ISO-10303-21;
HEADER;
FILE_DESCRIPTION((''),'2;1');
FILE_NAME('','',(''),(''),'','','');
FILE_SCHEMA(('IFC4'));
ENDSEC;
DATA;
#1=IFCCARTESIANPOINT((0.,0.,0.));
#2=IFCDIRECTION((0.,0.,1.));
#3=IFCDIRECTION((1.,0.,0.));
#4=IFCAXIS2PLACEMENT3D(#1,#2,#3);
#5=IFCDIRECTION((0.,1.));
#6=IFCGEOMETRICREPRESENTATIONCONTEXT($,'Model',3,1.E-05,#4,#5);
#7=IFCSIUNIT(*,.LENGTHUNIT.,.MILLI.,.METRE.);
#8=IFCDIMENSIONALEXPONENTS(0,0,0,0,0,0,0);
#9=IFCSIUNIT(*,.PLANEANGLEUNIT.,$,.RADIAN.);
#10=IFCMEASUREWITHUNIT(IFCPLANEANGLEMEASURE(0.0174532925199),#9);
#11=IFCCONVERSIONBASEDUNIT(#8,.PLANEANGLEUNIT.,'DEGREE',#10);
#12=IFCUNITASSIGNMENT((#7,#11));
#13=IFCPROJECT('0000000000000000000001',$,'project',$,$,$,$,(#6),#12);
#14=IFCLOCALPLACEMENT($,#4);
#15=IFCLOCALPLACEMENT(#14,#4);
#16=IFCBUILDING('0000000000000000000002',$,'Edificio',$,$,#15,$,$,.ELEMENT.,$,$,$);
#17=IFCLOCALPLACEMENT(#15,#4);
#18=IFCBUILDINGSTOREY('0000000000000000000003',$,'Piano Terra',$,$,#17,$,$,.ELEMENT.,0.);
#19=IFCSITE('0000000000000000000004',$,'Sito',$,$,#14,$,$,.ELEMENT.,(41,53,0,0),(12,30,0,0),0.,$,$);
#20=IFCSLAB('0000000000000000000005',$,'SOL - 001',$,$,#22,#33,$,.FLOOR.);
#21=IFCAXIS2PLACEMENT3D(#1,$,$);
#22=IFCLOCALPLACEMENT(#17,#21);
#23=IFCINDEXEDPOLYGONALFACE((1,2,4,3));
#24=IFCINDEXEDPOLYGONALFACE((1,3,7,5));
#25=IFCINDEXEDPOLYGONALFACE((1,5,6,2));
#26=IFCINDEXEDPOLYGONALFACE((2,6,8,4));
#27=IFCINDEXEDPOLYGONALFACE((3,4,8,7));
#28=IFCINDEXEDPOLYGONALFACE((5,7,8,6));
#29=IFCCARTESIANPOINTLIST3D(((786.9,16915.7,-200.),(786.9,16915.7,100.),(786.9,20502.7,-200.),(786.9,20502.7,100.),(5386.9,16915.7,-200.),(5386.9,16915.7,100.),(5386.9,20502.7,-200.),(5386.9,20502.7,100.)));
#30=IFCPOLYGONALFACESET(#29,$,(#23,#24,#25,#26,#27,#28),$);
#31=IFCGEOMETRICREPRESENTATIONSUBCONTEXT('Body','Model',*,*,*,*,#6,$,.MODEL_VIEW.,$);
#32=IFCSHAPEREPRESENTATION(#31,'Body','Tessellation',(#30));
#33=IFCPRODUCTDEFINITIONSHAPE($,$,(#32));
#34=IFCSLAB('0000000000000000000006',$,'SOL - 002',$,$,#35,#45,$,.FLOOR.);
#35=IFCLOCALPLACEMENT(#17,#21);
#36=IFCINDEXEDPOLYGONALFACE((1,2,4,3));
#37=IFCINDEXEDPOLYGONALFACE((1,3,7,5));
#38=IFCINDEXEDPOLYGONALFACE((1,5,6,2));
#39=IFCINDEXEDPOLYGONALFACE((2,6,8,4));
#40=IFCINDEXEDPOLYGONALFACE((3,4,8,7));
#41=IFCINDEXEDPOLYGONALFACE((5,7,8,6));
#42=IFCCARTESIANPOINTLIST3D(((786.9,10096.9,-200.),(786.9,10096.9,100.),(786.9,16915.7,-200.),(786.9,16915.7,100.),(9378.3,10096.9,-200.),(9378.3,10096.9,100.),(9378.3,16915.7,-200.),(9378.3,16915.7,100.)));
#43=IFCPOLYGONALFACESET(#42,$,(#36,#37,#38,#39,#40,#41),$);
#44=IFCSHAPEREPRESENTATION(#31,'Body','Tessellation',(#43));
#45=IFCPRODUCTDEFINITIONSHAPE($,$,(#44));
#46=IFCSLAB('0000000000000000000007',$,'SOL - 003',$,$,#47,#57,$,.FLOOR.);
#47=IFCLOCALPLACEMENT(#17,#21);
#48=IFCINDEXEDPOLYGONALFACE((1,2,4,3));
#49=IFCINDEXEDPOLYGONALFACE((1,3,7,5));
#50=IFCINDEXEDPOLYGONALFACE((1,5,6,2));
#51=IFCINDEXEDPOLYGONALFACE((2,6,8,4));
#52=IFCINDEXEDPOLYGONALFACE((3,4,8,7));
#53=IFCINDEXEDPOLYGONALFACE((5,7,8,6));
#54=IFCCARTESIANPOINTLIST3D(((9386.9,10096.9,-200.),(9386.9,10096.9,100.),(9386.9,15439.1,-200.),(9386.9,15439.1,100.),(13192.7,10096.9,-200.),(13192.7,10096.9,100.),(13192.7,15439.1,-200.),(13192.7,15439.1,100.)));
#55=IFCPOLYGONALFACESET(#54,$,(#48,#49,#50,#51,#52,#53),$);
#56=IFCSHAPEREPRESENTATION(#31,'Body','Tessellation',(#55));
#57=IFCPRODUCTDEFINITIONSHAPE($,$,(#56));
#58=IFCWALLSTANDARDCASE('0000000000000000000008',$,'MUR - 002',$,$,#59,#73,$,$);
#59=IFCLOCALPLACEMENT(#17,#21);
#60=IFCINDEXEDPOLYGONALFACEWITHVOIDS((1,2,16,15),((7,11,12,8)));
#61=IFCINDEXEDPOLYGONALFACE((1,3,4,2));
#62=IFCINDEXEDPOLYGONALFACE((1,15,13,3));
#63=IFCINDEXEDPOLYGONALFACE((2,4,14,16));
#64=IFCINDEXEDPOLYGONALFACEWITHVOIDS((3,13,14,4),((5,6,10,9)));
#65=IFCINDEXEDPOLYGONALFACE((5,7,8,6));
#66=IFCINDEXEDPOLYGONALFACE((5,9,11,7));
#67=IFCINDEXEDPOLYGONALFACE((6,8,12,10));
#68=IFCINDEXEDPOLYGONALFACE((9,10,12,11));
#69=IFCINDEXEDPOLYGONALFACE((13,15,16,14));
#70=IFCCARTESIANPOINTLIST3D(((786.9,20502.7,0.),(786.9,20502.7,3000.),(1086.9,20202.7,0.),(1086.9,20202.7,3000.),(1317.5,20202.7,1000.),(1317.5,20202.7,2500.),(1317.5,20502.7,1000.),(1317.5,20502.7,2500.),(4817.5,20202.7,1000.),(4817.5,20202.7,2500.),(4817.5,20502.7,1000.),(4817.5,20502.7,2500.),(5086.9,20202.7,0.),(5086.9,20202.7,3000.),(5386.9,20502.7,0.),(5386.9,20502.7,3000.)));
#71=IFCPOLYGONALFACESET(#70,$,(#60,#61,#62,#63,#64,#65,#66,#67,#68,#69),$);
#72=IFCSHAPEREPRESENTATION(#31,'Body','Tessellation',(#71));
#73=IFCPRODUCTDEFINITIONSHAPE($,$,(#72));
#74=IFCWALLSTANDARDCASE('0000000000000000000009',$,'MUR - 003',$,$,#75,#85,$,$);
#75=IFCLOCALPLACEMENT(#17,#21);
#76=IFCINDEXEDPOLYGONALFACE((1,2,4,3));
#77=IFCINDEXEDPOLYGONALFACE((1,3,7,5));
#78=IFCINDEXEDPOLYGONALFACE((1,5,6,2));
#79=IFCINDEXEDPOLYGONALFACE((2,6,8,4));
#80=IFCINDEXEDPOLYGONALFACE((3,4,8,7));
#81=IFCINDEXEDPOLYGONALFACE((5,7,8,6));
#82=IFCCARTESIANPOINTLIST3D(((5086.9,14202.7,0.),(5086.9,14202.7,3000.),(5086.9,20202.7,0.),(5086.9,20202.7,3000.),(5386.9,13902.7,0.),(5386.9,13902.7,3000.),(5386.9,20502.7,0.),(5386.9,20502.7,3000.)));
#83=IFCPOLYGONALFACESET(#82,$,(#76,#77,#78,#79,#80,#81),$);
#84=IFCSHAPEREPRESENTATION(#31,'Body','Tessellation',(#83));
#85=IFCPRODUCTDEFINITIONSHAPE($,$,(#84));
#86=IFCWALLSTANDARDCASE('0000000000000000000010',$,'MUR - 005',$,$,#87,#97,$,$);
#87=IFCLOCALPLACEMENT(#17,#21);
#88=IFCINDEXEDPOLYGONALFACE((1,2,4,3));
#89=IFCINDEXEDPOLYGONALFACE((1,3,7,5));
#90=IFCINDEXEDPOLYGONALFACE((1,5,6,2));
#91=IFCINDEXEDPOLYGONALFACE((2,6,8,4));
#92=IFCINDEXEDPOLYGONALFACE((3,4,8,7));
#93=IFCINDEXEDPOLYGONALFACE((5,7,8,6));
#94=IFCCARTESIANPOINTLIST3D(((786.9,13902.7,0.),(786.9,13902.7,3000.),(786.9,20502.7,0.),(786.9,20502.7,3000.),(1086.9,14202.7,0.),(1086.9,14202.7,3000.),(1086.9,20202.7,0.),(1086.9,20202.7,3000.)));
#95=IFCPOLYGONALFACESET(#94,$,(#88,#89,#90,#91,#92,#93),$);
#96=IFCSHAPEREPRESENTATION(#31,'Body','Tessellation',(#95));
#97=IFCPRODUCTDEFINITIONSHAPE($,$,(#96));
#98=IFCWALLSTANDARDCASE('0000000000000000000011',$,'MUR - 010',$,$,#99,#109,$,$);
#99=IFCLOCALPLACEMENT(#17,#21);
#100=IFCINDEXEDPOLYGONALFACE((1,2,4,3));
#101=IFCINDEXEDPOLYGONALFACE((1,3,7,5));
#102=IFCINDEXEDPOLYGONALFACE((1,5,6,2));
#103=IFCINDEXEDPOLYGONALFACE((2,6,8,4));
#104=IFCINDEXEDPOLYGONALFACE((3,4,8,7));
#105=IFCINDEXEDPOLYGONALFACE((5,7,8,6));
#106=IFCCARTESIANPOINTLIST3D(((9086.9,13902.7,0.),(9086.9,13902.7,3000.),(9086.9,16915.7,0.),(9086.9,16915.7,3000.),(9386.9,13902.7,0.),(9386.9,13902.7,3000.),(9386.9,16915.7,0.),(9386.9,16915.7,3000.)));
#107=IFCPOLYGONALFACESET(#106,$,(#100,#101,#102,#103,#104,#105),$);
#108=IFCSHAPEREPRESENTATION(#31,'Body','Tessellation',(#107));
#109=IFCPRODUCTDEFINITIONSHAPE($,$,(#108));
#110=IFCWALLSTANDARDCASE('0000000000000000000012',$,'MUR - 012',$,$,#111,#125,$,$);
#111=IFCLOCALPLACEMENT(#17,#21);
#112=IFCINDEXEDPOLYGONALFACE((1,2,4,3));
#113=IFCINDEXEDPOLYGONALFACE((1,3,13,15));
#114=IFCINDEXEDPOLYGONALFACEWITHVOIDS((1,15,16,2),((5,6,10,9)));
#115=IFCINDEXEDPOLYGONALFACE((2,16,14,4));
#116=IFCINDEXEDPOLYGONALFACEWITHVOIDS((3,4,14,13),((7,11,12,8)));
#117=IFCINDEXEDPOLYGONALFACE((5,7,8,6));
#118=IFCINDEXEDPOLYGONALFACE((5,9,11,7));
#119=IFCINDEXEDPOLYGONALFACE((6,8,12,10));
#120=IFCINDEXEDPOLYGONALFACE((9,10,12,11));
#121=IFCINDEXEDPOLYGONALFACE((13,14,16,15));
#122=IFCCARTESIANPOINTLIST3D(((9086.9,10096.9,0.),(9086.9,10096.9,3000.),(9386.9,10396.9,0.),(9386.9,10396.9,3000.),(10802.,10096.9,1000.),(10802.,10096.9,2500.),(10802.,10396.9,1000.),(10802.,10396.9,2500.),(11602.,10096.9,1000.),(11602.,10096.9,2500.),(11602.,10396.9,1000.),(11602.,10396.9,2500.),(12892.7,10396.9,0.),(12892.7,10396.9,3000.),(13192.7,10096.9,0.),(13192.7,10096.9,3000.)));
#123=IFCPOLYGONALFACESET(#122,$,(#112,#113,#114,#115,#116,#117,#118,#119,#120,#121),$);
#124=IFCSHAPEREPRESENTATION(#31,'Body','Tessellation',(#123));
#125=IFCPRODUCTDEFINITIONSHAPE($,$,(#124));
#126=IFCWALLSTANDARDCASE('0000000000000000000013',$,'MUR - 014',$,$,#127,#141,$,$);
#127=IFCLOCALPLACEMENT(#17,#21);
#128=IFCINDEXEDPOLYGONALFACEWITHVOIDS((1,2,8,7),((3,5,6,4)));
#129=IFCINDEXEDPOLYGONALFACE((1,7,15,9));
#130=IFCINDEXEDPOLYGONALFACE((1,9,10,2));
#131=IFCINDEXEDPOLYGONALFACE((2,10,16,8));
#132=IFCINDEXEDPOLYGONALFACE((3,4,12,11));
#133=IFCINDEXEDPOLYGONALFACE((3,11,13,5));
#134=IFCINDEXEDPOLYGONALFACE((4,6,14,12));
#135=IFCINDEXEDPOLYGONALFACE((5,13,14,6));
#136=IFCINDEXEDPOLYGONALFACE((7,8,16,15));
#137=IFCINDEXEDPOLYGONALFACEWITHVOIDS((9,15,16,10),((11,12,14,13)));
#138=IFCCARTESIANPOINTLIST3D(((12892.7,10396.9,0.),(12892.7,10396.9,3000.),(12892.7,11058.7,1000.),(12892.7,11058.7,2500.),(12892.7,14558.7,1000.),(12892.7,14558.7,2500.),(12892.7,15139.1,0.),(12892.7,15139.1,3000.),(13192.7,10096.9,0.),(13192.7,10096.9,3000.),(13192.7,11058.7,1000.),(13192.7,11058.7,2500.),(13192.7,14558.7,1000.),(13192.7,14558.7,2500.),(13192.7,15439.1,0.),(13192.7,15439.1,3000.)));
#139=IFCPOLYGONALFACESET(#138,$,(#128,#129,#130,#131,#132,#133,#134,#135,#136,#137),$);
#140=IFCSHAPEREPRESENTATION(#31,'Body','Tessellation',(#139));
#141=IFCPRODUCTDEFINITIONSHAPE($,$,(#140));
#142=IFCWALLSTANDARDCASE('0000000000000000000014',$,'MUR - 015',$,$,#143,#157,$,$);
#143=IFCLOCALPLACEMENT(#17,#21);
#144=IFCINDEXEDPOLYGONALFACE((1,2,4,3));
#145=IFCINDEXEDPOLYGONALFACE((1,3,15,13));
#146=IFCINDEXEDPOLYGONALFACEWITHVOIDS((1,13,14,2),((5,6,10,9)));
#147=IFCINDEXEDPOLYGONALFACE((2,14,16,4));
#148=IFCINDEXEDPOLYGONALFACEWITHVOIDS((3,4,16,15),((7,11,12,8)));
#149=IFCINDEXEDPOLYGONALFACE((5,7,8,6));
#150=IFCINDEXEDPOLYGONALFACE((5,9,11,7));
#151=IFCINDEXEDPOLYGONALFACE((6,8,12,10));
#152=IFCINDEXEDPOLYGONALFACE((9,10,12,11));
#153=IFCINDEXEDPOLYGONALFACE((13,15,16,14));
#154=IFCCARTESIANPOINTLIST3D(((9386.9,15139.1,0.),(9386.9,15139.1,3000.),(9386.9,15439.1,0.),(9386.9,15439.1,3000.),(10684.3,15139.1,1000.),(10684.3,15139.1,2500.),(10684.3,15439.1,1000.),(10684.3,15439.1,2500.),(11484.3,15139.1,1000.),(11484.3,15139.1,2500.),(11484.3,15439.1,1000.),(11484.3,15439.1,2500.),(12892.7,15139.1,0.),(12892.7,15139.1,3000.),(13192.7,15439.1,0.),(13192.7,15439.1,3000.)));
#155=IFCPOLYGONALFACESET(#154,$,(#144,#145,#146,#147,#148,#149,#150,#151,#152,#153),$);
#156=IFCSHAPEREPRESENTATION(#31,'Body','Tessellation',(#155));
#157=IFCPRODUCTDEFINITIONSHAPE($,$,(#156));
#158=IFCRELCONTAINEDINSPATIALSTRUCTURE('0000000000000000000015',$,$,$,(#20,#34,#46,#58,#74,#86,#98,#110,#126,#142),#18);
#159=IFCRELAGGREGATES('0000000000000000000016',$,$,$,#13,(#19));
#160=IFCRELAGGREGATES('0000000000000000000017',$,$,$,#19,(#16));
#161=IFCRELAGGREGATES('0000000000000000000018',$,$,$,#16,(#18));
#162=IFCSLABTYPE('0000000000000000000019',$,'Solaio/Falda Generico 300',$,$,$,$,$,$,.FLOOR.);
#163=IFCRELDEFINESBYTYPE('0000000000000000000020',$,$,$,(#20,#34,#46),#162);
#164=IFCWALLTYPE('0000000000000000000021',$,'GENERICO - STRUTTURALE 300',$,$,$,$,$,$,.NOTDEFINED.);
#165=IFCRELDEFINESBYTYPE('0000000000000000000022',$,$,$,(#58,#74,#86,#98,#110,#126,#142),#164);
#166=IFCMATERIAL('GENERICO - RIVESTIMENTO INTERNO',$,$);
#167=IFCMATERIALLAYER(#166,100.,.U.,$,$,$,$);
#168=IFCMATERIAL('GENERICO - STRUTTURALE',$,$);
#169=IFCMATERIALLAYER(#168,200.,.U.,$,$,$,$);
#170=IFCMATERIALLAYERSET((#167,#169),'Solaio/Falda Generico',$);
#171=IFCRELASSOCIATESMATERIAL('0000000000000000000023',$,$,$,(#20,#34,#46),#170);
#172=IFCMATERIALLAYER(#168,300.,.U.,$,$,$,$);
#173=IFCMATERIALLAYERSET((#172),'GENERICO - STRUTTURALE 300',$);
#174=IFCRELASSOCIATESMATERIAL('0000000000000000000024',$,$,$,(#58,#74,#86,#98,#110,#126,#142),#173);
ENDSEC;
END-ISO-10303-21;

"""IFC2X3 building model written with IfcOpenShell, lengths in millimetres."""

from ifc_helpers import new_model, entity, si_unit, converted_unit, direction, frame, origin_with_axes, origin_2d_with_axis, place, context, subcontext, project, spatial, polyline, rectangle, outline, extrude, material, layer, layer_set, layer_usage, type_object, element, save


model = new_model("IFC2X3")

# Units and contexts
model_context = context("Model", 3, precision=1e-05, world=origin_with_axes(), true_north=direction((0.0, 1.0)))
body_context = subcontext(model_context, "Body", "Model", "MODEL_VIEW")
ifc_project = project(units=[si_unit("LENGTHUNIT", "METRE", prefix="MILLI"), converted_unit("PLANEANGLEUNIT", "DEGREE", entity("IfcPlaneAngleMeasure", 0.0174532925199), si_unit("PLANEANGLEUNIT", "RADIAN"), dimensions=[0, 0, 0, 0, 0, 0, 0])], contexts=[model_context])

# Site, building, storey
site_placement = place(None, origin_with_axes())
site = spatial("IfcSite", under=ifc_project, at=site_placement, Name="Sito", CompositionType="ELEMENT", RefLatitude=(41, 53, 0, 0), RefLongitude=(12, 30, 0, 0), RefElevation=0.0)
building_placement = place(site_placement, origin_with_axes())
building = spatial("IfcBuilding", under=site, at=building_placement, Name="Edificio", CompositionType="ELEMENT")
storey_placement = place(building_placement, origin_with_axes())
storey = spatial("IfcBuildingStorey", under=building, at=storey_placement, Name="Piano Terra", CompositionType="ELEMENT", Elevation=0.0)

# Slabs
ifc_material_1 = material(Name="GENERICO - RIVESTIMENTO INTERNO")
ifc_layer_1 = layer(ifc_material_1, 100.0, ventilated="UNKNOWN")
ifc_material_2 = material(Name="GENERICO - STRUTTURALE")
ifc_layer_2 = layer(ifc_material_2, 200.0, ventilated="UNKNOWN")
ifc_layer_set_1 = layer_set([ifc_layer_1, ifc_layer_2], Name="Solaio/Falda Generico")
ifc_layer_usage_1 = layer_usage(ifc_layer_set_1, "AXIS3", "NEGATIVE", 300.0)
slab_type = type_object("IfcSlabType", Name="Solaio/Falda Generico 300", PredefinedType="FLOOR")
slab_1_placement = place(storey_placement, frame((786.9, 16915.7, 0.0), z_axis=(0.0, 0.0, 1.0), x_axis=(1.0, 0.0, 0.0)))
element("IfcSlab", 1, at=slab_1_placement, inside=storey, type_object=slab_type, material=ifc_layer_usage_1, Name="SOL - 001", PredefinedType="FLOOR", context=body_context, shape_type="SweptSolid", body=[
    extrude(outline(polyline([(0.0, 0.0), (4600.0, 0.0), (4600.0, 3587.1), (0.0, 3587.1), (0.0, 0.0)])), frame((0.0, 0.0, -200.0), z_axis=(0.0, 0.0, 1.0), x_axis=(1.0, 0.0, 0.0)), (0.0, 0.0, 1.0), 300.0),
])
ifc_layer_usage_2 = layer_usage(ifc_layer_set_1, "AXIS3", "NEGATIVE", 300.0)
slab_2_placement = place(storey_placement, frame((786.9, 10096.9, 0.0), z_axis=(0.0, 0.0, 1.0), x_axis=(1.0, 0.0, 0.0)))
element("IfcSlab", 2, at=slab_2_placement, inside=storey, type_object=slab_type, material=ifc_layer_usage_2, Name="SOL - 002", PredefinedType="FLOOR", context=body_context, shape_type="SweptSolid", body=[
    extrude(outline(polyline([(0.0, 0.0), (8591.4, 0.0), (8591.4, 6818.8), (0.0, 6818.8), (0.0, 0.0)])), frame((0.0, 0.0, -200.0), z_axis=(0.0, 0.0, 1.0), x_axis=(1.0, 0.0, 0.0)), (0.0, 0.0, 1.0), 300.0),
])
ifc_layer_usage_3 = layer_usage(ifc_layer_set_1, "AXIS3", "NEGATIVE", 300.0)
slab_3_placement = place(storey_placement, frame((9386.9, 10096.9, 0.0), z_axis=(0.0, 0.0, 1.0), x_axis=(1.0, 0.0, 0.0)))
element("IfcSlab", 3, at=slab_3_placement, inside=storey, type_object=slab_type, material=ifc_layer_usage_3, Name="SOL - 003", PredefinedType="FLOOR", context=body_context, shape_type="SweptSolid", body=[
    extrude(outline(polyline([(0.0, 0.0), (3805.8, 0.0), (3805.8, 5342.2), (0.0, 5342.2), (0.0, 0.0)])), frame((0.0, 0.0, -200.0), z_axis=(0.0, 0.0, 1.0), x_axis=(1.0, 0.0, 0.0)), (0.0, 0.0, 1.0), 300.0),
])

# Wall, opening
ifc_layer_3 = layer(ifc_material_2, 300.0, ventilated="UNKNOWN")
ifc_layer_set_2 = layer_set([ifc_layer_3], Name="GENERICO - STRUTTURALE 300")
ifc_layer_usage_4 = layer_usage(ifc_layer_set_2, "AXIS2", "POSITIVE", 0.0)
wall_type = type_object("IfcWallType", Name="GENERICO - STRUTTURALE 300", PredefinedType="NOTDEFINED")
wall_1_placement = place(storey_placement, frame((1086.9, 20202.7, 0.0), z_axis=(0.0, 0.0, 1.0), x_axis=(1.0, 0.0, 0.0)))
wall_1 = element("IfcWallStandardCase", 4, at=wall_1_placement, inside=storey, type_object=wall_type, material=ifc_layer_usage_4, Name="MUR - 002", context=body_context, shape_type="SweptSolid", body=[
    extrude(outline(polyline([(0.0, 0.0), (4000.0, 0.0), (4300.0, 300.0), (-300.0, 300.0), (0.0, 0.0)])), origin_with_axes(), (0.0, 0.0, 1.0), 3000.0),
])
opening_1_placement = place(wall_1_placement, frame((1980.6, 0.0, 1000.0), z_axis=(0.0, 0.0, 1.0), x_axis=(1.0, 0.0, 0.0)))
element("IfcOpeningElement", 5, at=opening_1_placement, cuts=wall_1, context=body_context, shape_type="SweptSolid", body=[
    extrude(rectangle(XDim=3500.0, YDim=1500.0, at=origin_2d_with_axis()), frame((0.0, -300.0, 750.0), z_axis=(0.0, 1.0, 0.0), x_axis=(1.0, 0.0, 0.0)), (0.0, 0.0, 1.0), 900.0),
])

# Wall
ifc_layer_usage_5 = layer_usage(ifc_layer_set_2, "AXIS2", "POSITIVE", 0.0)
wall_2_placement = place(storey_placement, frame((5086.9, 20202.7, 0.0), z_axis=(0.0, 0.0, 1.0), x_axis=(0.0, -1.0, 0.0)))
element("IfcWallStandardCase", 6, at=wall_2_placement, inside=storey, type_object=wall_type, material=ifc_layer_usage_5, Name="MUR - 003", context=body_context, shape_type="SweptSolid", body=[
    extrude(outline(polyline([(0.0, 0.0), (6000.0, 0.0), (6300.0, 300.0), (-300.0, 300.0), (0.0, 0.0)])), origin_with_axes(), (0.0, 0.0, 1.0), 3000.0),
])

# Wall
ifc_layer_usage_6 = layer_usage(ifc_layer_set_2, "AXIS2", "POSITIVE", 0.0)
wall_3_placement = place(storey_placement, frame((1086.9, 14202.7, 0.0), z_axis=(0.0, 0.0, 1.0), x_axis=(0.0, 1.0, 0.0)))
element("IfcWallStandardCase", 7, at=wall_3_placement, inside=storey, type_object=wall_type, material=ifc_layer_usage_6, Name="MUR - 005", context=body_context, shape_type="SweptSolid", body=[
    extrude(outline(polyline([(0.0, 0.0), (6000.0, 0.0), (6300.0, 300.0), (-300.0, 300.0), (0.0, 0.0)])), origin_with_axes(), (0.0, 0.0, 1.0), 3000.0),
])

# Wall
ifc_layer_usage_7 = layer_usage(ifc_layer_set_2, "AXIS2", "POSITIVE", 0.0)
wall_4_placement = place(storey_placement, frame((9386.9, 13902.7, 0.0), z_axis=(0.0, 0.0, 1.0), x_axis=(0.0, 1.0, 0.0)))
element("IfcWallStandardCase", 8, at=wall_4_placement, inside=storey, type_object=wall_type, material=ifc_layer_usage_7, Name="MUR - 010", context=body_context, shape_type="SweptSolid", body=[
    extrude(outline(polyline([(0.0, 0.0), (3012.9, 0.0), (3012.9, 300.0), (0.0, 300.0), (0.0, 0.0)])), origin_with_axes(), (0.0, 0.0, 1.0), 3000.0),
])

# Walls, openings
ifc_layer_usage_8 = layer_usage(ifc_layer_set_2, "AXIS2", "POSITIVE", -300.0)
wall_5_placement = place(storey_placement, frame((9386.9, 10396.9, 0.0), z_axis=(0.0, 0.0, 1.0), x_axis=(1.0, 0.0, 0.0)))
wall_5 = element("IfcWallStandardCase", 9, at=wall_5_placement, inside=storey, type_object=wall_type, material=ifc_layer_usage_8, Name="MUR - 012", context=body_context, shape_type="SweptSolid", body=[
    extrude(outline(polyline([(-300.0, -300.0), (3805.8, -300.0), (3505.8, 0.0), (0.0, 0.0), (-300.0, -300.0)])), origin_with_axes(), (0.0, 0.0, 1.0), 3000.0),
])
opening_2_placement = place(wall_5_placement, frame((1815.1, 0.0, 1000.0), z_axis=(0.0, 0.0, 1.0), x_axis=(1.0, 0.0, 0.0)))
element("IfcOpeningElement", 10, at=opening_2_placement, cuts=wall_5, context=body_context, shape_type="SweptSolid", body=[
    extrude(rectangle(XDim=800.0, YDim=1500.0, at=origin_2d_with_axis()), frame((0.0, 300.0, 750.0), z_axis=(0.0, -1.0, 0.0), x_axis=(-1.0, 0.0, 0.0)), (0.0, 0.0, 1.0), 900.0),
])
ifc_layer_usage_9 = layer_usage(ifc_layer_set_2, "AXIS2", "POSITIVE", -300.0)
wall_6_placement = place(storey_placement, frame((12892.7, 10396.9, 0.0), z_axis=(0.0, 0.0, 1.0), x_axis=(0.0, 1.0, 0.0)))
wall_6 = element("IfcWallStandardCase", 11, at=wall_6_placement, inside=storey, type_object=wall_type, material=ifc_layer_usage_9, Name="MUR - 014", context=body_context, shape_type="SweptSolid", body=[
    extrude(outline(polyline([(-300.0, -300.0), (5042.2, -300.0), (4742.2, 0.0), (0.0, 0.0), (-300.0, -300.0)])), origin_with_axes(), (0.0, 0.0, 1.0), 3000.0),
])
opening_3_placement = place(wall_6_placement, frame((2411.8, 0.0, 1000.0), z_axis=(0.0, 0.0, 1.0), x_axis=(1.0, 0.0, 0.0)))
element("IfcOpeningElement", 12, at=opening_3_placement, cuts=wall_6, context=body_context, shape_type="SweptSolid", body=[
    extrude(rectangle(XDim=3500.0, YDim=1500.0, at=origin_2d_with_axis()), frame((0.0, 300.0, 750.0), z_axis=(0.0, 1.0, 0.0), x_axis=(1.0, 0.0, 0.0)), (0.0, 0.0, -1.0), 900.0),
])
ifc_layer_usage_10 = layer_usage(ifc_layer_set_2, "AXIS2", "POSITIVE", -300.0)
wall_7_placement = place(storey_placement, frame((12892.7, 15139.1, 0.0), z_axis=(0.0, 0.0, 1.0), x_axis=(-1.0, 0.0, 0.0)))
wall_7 = element("IfcWallStandardCase", 13, at=wall_7_placement, inside=storey, type_object=wall_type, material=ifc_layer_usage_10, Name="MUR - 015", context=body_context, shape_type="SweptSolid", body=[
    extrude(outline(polyline([(-300.0, -300.0), (3505.8, -300.0), (3505.8, 0.0), (0.0, 0.0), (-300.0, -300.0)])), origin_with_axes(), (0.0, 0.0, 1.0), 3000.0),
])
opening_4_placement = place(wall_7_placement, frame((1808.4, 0.0, 1000.0), z_axis=(0.0, 0.0, 1.0), x_axis=(1.0, 0.0, 0.0)))
element("IfcOpeningElement", 14, at=opening_4_placement, cuts=wall_7, context=body_context, shape_type="SweptSolid", body=[
    extrude(rectangle(XDim=800.0, YDim=1500.0, at=origin_2d_with_axis()), frame((0.0, 300.0, 750.0), z_axis=(0.0, -1.0, 0.0), x_axis=(-1.0, 0.0, 0.0)), (0.0, 0.0, 1.0), 900.0),
])

save(model, "model.ifc")
